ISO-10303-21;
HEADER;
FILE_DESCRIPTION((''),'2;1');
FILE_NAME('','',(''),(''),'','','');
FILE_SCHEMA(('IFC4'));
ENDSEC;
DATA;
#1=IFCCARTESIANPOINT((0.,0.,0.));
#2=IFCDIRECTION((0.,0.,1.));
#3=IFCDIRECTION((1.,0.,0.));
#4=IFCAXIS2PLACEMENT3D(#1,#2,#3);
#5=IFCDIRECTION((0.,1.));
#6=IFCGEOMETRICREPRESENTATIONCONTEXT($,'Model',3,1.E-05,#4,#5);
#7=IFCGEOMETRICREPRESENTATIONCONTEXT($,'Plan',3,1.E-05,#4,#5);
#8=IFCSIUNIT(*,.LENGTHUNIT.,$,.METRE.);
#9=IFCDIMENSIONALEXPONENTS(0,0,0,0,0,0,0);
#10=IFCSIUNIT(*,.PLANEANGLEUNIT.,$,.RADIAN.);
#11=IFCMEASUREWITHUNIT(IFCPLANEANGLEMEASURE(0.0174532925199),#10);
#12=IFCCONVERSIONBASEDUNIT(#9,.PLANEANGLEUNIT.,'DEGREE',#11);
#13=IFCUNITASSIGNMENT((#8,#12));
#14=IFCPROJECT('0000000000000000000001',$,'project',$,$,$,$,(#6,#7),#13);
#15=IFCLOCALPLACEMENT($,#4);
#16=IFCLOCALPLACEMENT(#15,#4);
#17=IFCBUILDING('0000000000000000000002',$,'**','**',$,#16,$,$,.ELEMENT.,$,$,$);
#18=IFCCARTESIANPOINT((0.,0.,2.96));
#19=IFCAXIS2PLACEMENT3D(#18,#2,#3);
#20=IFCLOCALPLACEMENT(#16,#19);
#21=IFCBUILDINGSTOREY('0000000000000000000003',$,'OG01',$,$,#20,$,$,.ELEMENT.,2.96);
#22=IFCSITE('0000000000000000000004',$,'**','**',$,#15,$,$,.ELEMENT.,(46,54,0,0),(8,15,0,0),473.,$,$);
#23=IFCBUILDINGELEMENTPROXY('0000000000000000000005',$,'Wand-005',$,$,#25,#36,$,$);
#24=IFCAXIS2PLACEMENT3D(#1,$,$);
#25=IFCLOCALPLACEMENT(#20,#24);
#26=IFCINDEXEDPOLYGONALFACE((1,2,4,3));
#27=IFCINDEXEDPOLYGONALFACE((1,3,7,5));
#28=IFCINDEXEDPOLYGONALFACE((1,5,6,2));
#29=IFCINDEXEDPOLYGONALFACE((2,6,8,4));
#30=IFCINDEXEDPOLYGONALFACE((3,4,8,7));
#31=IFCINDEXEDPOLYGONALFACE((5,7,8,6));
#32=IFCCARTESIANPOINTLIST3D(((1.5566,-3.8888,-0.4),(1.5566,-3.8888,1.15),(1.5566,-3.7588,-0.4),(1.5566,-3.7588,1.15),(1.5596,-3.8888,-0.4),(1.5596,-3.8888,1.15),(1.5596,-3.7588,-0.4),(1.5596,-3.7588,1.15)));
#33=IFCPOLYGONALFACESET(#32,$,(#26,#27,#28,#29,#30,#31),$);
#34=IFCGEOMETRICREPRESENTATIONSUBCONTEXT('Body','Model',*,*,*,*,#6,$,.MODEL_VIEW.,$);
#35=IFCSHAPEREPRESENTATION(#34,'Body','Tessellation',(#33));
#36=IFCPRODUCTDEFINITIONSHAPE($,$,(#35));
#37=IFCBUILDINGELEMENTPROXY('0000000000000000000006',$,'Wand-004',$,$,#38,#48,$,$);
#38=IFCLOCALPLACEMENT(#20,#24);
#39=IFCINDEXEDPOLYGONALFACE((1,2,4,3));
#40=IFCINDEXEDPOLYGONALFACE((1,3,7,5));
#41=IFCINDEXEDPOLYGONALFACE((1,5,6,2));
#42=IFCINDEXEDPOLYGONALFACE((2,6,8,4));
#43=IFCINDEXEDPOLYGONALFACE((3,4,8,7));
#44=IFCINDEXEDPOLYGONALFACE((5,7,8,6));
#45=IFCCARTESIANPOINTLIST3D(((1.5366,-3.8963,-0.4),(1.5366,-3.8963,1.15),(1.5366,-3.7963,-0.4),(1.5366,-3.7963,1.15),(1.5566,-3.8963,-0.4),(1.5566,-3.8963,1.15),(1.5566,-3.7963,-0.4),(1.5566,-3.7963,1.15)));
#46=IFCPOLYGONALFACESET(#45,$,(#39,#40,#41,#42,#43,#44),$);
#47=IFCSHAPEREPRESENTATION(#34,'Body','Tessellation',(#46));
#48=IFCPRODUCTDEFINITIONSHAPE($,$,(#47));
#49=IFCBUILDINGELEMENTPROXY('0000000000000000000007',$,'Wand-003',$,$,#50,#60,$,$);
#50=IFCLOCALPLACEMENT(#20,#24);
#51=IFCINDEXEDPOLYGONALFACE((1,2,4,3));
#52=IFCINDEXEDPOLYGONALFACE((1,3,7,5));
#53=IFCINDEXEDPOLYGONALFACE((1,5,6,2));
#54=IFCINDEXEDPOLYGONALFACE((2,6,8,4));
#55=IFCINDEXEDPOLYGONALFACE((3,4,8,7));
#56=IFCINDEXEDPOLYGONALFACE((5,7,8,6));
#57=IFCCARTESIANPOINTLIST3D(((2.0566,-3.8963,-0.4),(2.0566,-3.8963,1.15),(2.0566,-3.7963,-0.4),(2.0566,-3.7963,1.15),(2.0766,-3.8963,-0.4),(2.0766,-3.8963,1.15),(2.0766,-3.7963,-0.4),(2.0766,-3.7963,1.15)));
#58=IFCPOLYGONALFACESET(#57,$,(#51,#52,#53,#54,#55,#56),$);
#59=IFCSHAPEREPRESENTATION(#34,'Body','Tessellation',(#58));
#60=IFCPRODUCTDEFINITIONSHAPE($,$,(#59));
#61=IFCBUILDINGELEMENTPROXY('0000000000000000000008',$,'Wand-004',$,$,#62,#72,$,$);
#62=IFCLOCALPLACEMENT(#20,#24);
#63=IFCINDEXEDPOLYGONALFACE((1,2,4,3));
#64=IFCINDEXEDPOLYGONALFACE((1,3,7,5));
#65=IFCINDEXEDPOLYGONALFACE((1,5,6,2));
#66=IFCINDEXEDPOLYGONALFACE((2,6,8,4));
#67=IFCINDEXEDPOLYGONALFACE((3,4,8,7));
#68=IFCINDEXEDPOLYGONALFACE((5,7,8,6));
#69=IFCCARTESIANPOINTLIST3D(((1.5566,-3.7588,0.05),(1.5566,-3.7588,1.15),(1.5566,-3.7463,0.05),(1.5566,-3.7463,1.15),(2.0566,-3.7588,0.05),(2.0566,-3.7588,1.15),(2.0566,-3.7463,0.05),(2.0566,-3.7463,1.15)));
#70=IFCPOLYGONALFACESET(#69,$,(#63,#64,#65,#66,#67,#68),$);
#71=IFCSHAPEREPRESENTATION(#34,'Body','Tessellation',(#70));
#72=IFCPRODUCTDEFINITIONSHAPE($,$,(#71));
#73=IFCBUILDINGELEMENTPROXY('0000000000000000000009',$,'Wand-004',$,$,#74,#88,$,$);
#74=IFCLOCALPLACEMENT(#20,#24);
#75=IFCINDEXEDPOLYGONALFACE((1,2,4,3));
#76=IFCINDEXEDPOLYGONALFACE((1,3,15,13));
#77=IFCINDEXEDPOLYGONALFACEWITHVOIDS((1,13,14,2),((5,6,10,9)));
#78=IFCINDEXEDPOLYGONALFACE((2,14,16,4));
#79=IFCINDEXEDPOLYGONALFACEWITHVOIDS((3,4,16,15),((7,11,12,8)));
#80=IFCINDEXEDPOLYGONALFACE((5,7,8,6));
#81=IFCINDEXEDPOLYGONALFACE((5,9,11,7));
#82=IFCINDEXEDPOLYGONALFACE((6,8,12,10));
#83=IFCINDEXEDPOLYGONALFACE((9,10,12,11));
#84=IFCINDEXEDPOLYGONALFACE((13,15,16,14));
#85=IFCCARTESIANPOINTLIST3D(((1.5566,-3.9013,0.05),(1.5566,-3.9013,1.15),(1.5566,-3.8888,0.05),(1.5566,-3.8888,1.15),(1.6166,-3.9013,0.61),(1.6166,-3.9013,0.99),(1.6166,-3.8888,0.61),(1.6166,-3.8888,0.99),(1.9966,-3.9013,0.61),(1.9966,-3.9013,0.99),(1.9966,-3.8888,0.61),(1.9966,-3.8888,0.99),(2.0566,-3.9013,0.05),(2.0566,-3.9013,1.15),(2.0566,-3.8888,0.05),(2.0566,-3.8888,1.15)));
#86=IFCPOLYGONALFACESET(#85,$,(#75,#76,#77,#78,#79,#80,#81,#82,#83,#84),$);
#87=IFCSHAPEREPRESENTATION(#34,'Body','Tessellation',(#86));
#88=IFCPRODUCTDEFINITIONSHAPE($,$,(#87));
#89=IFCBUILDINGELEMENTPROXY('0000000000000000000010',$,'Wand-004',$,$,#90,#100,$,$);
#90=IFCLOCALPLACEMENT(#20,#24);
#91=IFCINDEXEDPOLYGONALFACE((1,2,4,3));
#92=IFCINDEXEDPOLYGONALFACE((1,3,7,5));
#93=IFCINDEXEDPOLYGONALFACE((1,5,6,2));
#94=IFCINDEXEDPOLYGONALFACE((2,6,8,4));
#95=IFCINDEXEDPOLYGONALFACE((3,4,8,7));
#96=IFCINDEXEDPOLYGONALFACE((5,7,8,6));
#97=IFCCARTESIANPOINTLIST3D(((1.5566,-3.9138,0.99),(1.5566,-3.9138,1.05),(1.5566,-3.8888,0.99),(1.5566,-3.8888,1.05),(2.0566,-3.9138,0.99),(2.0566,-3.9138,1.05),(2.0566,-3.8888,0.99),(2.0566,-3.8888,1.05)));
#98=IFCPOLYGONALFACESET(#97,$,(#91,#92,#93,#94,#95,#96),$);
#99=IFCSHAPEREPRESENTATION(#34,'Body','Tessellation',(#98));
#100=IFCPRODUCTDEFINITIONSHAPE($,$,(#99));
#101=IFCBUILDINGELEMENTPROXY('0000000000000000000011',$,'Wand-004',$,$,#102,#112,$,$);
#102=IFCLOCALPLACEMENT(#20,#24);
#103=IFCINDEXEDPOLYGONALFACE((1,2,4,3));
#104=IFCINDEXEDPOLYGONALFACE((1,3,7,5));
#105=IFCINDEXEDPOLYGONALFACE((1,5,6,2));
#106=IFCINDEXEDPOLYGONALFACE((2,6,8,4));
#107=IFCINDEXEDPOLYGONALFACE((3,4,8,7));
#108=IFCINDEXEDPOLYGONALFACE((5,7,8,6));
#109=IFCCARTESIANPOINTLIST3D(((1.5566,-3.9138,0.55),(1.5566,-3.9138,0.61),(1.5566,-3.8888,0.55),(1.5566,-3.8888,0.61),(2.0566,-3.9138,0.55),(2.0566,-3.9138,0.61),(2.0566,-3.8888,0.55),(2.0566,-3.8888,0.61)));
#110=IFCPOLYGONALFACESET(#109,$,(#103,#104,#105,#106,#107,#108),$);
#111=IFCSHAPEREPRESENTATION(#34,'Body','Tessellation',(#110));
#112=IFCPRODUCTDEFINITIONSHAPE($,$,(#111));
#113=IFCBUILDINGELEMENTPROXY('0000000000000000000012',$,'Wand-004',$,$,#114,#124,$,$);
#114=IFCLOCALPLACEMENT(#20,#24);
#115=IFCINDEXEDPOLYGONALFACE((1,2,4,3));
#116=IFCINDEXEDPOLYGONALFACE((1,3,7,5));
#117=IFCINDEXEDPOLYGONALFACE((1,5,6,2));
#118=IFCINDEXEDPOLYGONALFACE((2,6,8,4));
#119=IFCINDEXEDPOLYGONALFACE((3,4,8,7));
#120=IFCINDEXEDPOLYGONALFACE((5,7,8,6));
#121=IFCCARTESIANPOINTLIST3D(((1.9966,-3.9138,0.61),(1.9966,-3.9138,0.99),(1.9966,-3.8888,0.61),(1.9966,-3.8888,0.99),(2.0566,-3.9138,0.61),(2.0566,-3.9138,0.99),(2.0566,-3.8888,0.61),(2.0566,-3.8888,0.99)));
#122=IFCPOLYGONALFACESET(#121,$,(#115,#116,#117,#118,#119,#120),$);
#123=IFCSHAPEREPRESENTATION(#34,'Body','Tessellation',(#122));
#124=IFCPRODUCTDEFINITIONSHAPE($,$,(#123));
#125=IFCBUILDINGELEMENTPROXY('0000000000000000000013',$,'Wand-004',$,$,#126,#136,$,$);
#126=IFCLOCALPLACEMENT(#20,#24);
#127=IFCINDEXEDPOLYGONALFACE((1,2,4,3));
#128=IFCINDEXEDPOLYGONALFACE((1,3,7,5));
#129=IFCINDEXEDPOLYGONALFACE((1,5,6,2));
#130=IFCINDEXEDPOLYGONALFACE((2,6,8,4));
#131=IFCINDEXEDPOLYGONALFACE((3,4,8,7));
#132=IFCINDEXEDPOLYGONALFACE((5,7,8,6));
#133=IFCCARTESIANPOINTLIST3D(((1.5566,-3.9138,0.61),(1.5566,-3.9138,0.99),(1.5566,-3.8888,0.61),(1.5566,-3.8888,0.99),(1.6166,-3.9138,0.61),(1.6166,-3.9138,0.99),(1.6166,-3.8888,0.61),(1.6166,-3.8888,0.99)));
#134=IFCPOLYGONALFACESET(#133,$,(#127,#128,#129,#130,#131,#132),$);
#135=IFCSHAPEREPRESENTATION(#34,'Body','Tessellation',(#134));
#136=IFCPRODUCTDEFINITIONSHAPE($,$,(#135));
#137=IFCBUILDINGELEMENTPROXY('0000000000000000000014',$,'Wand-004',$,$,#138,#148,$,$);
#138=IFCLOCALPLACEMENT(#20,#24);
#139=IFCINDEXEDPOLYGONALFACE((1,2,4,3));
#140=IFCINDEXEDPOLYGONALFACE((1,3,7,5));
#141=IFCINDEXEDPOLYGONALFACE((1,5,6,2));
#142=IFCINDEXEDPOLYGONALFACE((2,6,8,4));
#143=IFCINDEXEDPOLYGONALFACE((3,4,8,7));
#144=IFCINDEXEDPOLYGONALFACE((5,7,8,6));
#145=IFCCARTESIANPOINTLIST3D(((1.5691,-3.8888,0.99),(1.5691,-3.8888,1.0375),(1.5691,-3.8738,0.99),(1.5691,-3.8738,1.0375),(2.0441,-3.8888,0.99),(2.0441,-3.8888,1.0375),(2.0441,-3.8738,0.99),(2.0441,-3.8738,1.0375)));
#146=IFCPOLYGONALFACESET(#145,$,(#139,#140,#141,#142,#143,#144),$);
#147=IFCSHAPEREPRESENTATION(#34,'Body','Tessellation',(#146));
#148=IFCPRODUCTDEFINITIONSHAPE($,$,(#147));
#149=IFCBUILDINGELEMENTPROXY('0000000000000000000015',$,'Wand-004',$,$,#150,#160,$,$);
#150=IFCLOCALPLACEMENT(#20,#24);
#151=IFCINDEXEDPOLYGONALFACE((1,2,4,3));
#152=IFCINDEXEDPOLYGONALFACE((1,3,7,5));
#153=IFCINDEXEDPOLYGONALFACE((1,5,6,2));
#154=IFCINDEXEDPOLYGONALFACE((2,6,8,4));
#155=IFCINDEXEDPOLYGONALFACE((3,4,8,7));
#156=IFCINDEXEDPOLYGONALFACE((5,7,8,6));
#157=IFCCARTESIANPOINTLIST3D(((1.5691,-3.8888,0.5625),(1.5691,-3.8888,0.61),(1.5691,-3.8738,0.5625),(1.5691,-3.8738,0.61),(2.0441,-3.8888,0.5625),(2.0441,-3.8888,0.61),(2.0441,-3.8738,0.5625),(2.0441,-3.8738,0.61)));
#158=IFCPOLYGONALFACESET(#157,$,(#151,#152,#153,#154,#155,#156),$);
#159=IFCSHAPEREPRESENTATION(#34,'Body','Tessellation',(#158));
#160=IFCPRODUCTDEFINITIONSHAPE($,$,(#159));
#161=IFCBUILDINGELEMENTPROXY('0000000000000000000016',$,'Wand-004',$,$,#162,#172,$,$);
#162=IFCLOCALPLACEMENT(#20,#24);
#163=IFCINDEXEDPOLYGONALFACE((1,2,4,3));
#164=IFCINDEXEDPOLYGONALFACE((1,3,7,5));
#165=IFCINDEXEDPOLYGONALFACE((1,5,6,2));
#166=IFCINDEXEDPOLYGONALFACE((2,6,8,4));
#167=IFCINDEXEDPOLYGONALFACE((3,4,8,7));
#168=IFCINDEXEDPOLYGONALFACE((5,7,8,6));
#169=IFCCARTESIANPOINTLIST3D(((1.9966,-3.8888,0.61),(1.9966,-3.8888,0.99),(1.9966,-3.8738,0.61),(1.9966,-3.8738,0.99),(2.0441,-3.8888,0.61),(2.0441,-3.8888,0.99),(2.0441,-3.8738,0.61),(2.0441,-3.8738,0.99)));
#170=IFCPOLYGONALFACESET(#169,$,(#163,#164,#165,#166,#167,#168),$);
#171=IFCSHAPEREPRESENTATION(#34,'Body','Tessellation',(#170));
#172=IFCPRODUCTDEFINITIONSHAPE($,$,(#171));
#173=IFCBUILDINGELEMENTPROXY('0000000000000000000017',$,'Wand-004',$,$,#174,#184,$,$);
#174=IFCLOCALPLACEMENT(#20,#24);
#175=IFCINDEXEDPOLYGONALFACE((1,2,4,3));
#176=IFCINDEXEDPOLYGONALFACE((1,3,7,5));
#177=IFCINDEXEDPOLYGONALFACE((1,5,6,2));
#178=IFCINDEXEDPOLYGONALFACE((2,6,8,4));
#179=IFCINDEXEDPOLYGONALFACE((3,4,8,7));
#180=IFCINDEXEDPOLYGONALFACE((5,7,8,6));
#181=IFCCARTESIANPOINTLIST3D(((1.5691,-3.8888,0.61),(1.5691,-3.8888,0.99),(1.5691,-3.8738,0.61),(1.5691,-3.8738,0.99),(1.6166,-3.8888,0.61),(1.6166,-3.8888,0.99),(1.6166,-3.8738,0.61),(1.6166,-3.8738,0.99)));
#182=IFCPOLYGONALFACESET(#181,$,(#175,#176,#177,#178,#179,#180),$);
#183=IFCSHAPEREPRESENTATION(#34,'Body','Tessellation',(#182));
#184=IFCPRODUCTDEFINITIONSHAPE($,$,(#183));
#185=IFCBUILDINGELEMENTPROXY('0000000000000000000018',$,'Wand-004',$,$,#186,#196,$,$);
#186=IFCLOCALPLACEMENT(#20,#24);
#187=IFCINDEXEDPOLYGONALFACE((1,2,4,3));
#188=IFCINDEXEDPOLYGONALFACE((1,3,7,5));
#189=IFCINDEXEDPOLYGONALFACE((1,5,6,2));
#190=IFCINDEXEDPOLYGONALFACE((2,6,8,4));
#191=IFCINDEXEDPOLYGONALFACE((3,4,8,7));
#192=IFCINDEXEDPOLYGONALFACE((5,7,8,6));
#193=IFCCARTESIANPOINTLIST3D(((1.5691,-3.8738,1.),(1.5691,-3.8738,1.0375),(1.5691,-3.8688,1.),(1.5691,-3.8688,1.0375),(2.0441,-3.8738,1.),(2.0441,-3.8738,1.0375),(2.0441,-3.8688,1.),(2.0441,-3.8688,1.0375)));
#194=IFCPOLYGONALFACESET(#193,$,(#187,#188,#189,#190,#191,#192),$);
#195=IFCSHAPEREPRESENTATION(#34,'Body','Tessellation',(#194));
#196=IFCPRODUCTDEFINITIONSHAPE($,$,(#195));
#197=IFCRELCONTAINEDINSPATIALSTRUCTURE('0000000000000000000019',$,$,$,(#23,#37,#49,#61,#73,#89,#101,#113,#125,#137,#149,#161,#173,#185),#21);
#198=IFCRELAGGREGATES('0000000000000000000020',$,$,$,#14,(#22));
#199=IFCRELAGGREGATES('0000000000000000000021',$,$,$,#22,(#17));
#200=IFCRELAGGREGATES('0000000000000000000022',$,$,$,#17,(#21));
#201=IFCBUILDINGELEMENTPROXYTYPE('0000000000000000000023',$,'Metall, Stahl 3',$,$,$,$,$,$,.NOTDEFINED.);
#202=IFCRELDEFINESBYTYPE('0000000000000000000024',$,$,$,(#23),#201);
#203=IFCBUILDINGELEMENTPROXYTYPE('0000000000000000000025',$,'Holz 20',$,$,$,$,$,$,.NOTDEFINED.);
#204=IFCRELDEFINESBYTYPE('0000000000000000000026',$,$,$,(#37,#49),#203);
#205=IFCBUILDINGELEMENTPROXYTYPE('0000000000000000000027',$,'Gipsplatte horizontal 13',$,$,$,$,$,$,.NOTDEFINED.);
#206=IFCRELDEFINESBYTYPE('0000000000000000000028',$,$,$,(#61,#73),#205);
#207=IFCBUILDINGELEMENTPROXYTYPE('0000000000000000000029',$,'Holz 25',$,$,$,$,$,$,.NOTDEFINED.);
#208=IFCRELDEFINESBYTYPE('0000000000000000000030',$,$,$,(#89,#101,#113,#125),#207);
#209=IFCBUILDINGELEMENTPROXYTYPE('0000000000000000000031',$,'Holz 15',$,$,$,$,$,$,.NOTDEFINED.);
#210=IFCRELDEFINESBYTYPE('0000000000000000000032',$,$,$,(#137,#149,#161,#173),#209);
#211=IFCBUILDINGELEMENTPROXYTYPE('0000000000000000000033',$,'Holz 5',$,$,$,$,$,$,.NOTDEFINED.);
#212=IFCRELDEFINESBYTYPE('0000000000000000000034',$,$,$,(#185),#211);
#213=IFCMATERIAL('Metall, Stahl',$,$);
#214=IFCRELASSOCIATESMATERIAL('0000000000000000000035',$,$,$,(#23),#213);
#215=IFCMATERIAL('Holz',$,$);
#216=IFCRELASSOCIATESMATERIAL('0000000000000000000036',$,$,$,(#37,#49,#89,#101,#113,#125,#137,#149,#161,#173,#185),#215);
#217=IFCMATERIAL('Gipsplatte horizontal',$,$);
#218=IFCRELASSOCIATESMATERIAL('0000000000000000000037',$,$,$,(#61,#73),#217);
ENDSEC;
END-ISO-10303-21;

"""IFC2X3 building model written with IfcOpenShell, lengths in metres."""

from ifc_helpers import new_model, entity, si_unit, converted_unit, direction, frame, origin_with_axes, origin_2d_with_axis, place, context, subcontext, project, spatial, polyline, rectangle, outline, extrude, material, type_object, element, save


model = new_model("IFC2X3")

# Units and contexts
model_context = context("Model", 3, precision=1e-05, world=origin_with_axes(), true_north=direction((0.0, 1.0)))
plan_context = context("Plan", 3, precision=1e-05, world=origin_with_axes(), true_north=direction((0.0, 1.0)))
body_context = subcontext(model_context, "Body", "Model", "MODEL_VIEW")
ifc_project = project(units=[si_unit("LENGTHUNIT", "METRE"), converted_unit("PLANEANGLEUNIT", "DEGREE", entity("IfcPlaneAngleMeasure", 0.0174532925199), si_unit("PLANEANGLEUNIT", "RADIAN"), dimensions=[0, 0, 0, 0, 0, 0, 0])], contexts=[model_context, plan_context])

# Site, building, storey
site_placement = place(None, origin_with_axes())
site = spatial("IfcSite", under=ifc_project, at=site_placement, Name="**", Description="**", CompositionType="ELEMENT", RefLatitude=(46, 54, 0, 0), RefLongitude=(8, 15, 0, 0), RefElevation=473.0)
building_placement = place(site_placement, origin_with_axes())
building = spatial("IfcBuilding", under=site, at=building_placement, Name="**", Description="**", CompositionType="ELEMENT")
storey_placement = place(building_placement, frame((0.0, 0.0, 2.96), z_axis=(0.0, 0.0, 1.0), x_axis=(1.0, 0.0, 0.0)))
storey = spatial("IfcBuildingStorey", under=building, at=storey_placement, Name="OG01", CompositionType="ELEMENT", Elevation=2.96)

# Building element proxies
ifc_material_1 = material(Name="Metall, Stahl")
building_element_proxy_type_1 = type_object("IfcBuildingElementProxyType", Name="Metall, Stahl 3", PredefinedType="NOTDEFINED")
proxy_1_placement = place(storey_placement, frame((1.5566, -3.7588, -0.4), z_axis=(0.0, 0.0, 1.0), x_axis=(0.0, -1.0, 0.0)))
element("IfcBuildingElementProxy", 1, at=proxy_1_placement, inside=storey, type_object=building_element_proxy_type_1, material=ifc_material_1, Name="Wand-005", context=body_context, shape_type="SweptSolid", body=[
    extrude(outline(polyline([(0.0, 0.0), (0.13, 0.0), (0.13, 0.003), (0.0, 0.003), (0.0, 0.0)])), origin_with_axes(), (0.0, 0.0, 1.0), 1.55),
])
ifc_material_2 = material(Name="Holz")
building_element_proxy_type_2 = type_object("IfcBuildingElementProxyType", Name="Holz 20", PredefinedType="NOTDEFINED")
proxy_2_placement = place(storey_placement, frame((1.5366, -3.7963, -0.4), z_axis=(0.0, 0.0, 1.0), x_axis=(0.0, -1.0, 0.0)))
element("IfcBuildingElementProxy", 2, at=proxy_2_placement, inside=storey, type_object=building_element_proxy_type_2, material=ifc_material_2, Name="Wand-004", context=body_context, shape_type="SweptSolid", body=[
    extrude(outline(polyline([(0.0, 0.0), (0.1, 0.0), (0.1, 0.02), (0.0, 0.02), (0.0, 0.0)])), origin_with_axes(), (0.0, 0.0, 1.0), 1.55),
])
proxy_3_placement = place(storey_placement, frame((2.0766, -3.7963, -0.4), z_axis=(0.0, 0.0, 1.0), x_axis=(0.0, -1.0, 0.0)))
element("IfcBuildingElementProxy", 3, at=proxy_3_placement, inside=storey, type_object=building_element_proxy_type_2, material=ifc_material_2, Name="Wand-003", context=body_context, shape_type="SweptSolid", body=[
    extrude(outline(polyline([(0.0, -0.02), (0.1, -0.02), (0.1, 0.0), (0.0, 0.0), (0.0, -0.02)])), origin_with_axes(), (0.0, 0.0, 1.0), 1.55),
])
ifc_material_3 = material(Name="Gipsplatte horizontal")
building_element_proxy_type_3 = type_object("IfcBuildingElementProxyType", Name="Gipsplatte horizontal 13", PredefinedType="NOTDEFINED")
proxy_4_placement = place(storey_placement, frame((1.5566, -3.7463, 0.05), z_axis=(0.0, 0.0, 1.0), x_axis=(1.0, 0.0, 0.0)))
element("IfcBuildingElementProxy", 4, at=proxy_4_placement, inside=storey, type_object=building_element_proxy_type_3, material=ifc_material_3, Name="Wand-004", context=body_context, shape_type="SweptSolid", body=[
    extrude(outline(polyline([(0.0, -0.0125), (0.5, -0.0125), (0.5, 0.0), (0.0, 0.0), (0.0, -0.0125)])), origin_with_axes(), (0.0, 0.0, 1.0), 1.1),
])

# Building element proxy, opening
proxy_5_placement = place(storey_placement, frame((1.5566, -3.9013, 0.05), z_axis=(0.0, 0.0, 1.0), x_axis=(1.0, 0.0, 0.0)))
proxy_5 = element("IfcBuildingElementProxy", 5, at=proxy_5_placement, inside=storey, type_object=building_element_proxy_type_3, material=ifc_material_3, Name="Wand-004", context=body_context, shape_type="SweptSolid", body=[
    extrude(outline(polyline([(0.0, 0.0), (0.5, 0.0), (0.5, 0.0125), (0.0, 0.0125), (0.0, 0.0)])), origin_with_axes(), (0.0, 0.0, 1.0), 1.1),
])
opening_placement = place(proxy_5_placement, frame((-1.5566, 3.9013, -3.01), z_axis=(0.0, 0.0, 1.0), x_axis=(1.0, 0.0, 0.0)))
element("IfcOpeningElement", 6, at=opening_placement, cuts=proxy_5, context=body_context, shape_type="SweptSolid", body=[
    extrude(rectangle(XDim=0.38, YDim=0.38, at=origin_2d_with_axis()), frame((1.8066, -3.9138, 3.76), z_axis=(0.0, -1.0, 0.0), x_axis=(1.0, 0.0, 0.0)), (0.0, 0.0, -1.0), 0.0375),
])

# Building element proxies
building_element_proxy_type_4 = type_object("IfcBuildingElementProxyType", Name="Holz 25", PredefinedType="NOTDEFINED")
for number, where, z_axis, x_axis, name in (
    (7, (2.0566, -3.8888, 0.99), (0.0, 0.0, 1.0), (-1.0, 0.0, 0.0), "Wand-004"),
    (8, (2.0566, -3.8888, 0.55), (0.0, 0.0, 1.0), (-1.0, 0.0, 0.0), "Wand-004"),
):
    element("IfcBuildingElementProxy", number, at=place(storey_placement, frame(where, z_axis=z_axis, x_axis=x_axis)), inside=storey, type_object=building_element_proxy_type_4, material=ifc_material_2, Name=name, context=body_context, shape_type="SweptSolid", body=[
        extrude(outline(polyline([(0.0, 0.0), (0.5, 0.0), (0.5, 0.025), (0.0, 0.025), (0.0, 0.0)])), origin_with_axes(), (0.0, 0.0, 1.0), 0.06),
    ])
for number, where, z_axis, x_axis, name in (
    (9, (1.9966, -3.9138, 0.61), (0.0, 0.0, 1.0), (1.0, 0.0, 0.0), "Wand-004"),
    (10, (1.5566, -3.9138, 0.61), (0.0, 0.0, 1.0), (1.0, 0.0, 0.0), "Wand-004"),
):
    element("IfcBuildingElementProxy", number, at=place(storey_placement, frame(where, z_axis=z_axis, x_axis=x_axis)), inside=storey, type_object=building_element_proxy_type_4, material=ifc_material_2, Name=name, context=body_context, shape_type="SweptSolid", body=[
        extrude(outline(polyline([(0.0, 0.0), (0.06, 0.0), (0.06, 0.025), (0.0, 0.025), (0.0, 0.0)])), origin_with_axes(), (0.0, 0.0, 1.0), 0.38),
    ])
building_element_proxy_type_5 = type_object("IfcBuildingElementProxyType", Name="Holz 15", PredefinedType="NOTDEFINED")
for number, where, z_axis, x_axis, name in (
    (11, (2.0441, -3.8738, 0.99), (0.0, 0.0, 1.0), (-1.0, 0.0, 0.0), "Wand-004"),
    (12, (2.0441, -3.8738, 0.5625), (0.0, 0.0, 1.0), (-1.0, 0.0, 0.0), "Wand-004"),
):
    element("IfcBuildingElementProxy", number, at=place(storey_placement, frame(where, z_axis=z_axis, x_axis=x_axis)), inside=storey, type_object=building_element_proxy_type_5, material=ifc_material_2, Name=name, context=body_context, shape_type="SweptSolid", body=[
        extrude(outline(polyline([(0.0, 0.0), (0.475, 0.0), (0.475, 0.015), (0.0, 0.015), (0.0, 0.0)])), origin_with_axes(), (0.0, 0.0, 1.0), 0.0475),
    ])
for number, where, z_axis, x_axis, name in (
    (13, (1.9966, -3.8888, 0.61), (0.0, 0.0, 1.0), (1.0, 0.0, 0.0), "Wand-004"),
    (14, (1.5691, -3.8888, 0.61), (0.0, 0.0, 1.0), (1.0, 0.0, 0.0), "Wand-004"),
):
    element("IfcBuildingElementProxy", number, at=place(storey_placement, frame(where, z_axis=z_axis, x_axis=x_axis)), inside=storey, type_object=building_element_proxy_type_5, material=ifc_material_2, Name=name, context=body_context, shape_type="SweptSolid", body=[
        extrude(outline(polyline([(0.0, 0.0), (0.0475, 0.0), (0.0475, 0.015), (0.0, 0.015), (0.0, 0.0)])), origin_with_axes(), (0.0, 0.0, 1.0), 0.38),
    ])
building_element_proxy_type_6 = type_object("IfcBuildingElementProxyType", Name="Holz 5", PredefinedType="NOTDEFINED")
for number, where, z_axis, x_axis, name in (
    (15, (2.0441, -3.8738, 1.0), (0.0, 0.0, 1.0), (-1.0, 0.0, 0.0), "Wand-004"),
):
    element("IfcBuildingElementProxy", number, at=place(storey_placement, frame(where, z_axis=z_axis, x_axis=x_axis)), inside=storey, type_object=building_element_proxy_type_6, material=ifc_material_2, Name=name, context=body_context, shape_type="SweptSolid", body=[
        extrude(outline(polyline([(0.0, -0.005), (0.475, -0.005), (0.475, 0.0), (0.0, 0.0), (0.0, -0.005)])), origin_with_axes(), (0.0, 0.0, 1.0), 0.0375),
    ])

save(model, "model.ifc")
